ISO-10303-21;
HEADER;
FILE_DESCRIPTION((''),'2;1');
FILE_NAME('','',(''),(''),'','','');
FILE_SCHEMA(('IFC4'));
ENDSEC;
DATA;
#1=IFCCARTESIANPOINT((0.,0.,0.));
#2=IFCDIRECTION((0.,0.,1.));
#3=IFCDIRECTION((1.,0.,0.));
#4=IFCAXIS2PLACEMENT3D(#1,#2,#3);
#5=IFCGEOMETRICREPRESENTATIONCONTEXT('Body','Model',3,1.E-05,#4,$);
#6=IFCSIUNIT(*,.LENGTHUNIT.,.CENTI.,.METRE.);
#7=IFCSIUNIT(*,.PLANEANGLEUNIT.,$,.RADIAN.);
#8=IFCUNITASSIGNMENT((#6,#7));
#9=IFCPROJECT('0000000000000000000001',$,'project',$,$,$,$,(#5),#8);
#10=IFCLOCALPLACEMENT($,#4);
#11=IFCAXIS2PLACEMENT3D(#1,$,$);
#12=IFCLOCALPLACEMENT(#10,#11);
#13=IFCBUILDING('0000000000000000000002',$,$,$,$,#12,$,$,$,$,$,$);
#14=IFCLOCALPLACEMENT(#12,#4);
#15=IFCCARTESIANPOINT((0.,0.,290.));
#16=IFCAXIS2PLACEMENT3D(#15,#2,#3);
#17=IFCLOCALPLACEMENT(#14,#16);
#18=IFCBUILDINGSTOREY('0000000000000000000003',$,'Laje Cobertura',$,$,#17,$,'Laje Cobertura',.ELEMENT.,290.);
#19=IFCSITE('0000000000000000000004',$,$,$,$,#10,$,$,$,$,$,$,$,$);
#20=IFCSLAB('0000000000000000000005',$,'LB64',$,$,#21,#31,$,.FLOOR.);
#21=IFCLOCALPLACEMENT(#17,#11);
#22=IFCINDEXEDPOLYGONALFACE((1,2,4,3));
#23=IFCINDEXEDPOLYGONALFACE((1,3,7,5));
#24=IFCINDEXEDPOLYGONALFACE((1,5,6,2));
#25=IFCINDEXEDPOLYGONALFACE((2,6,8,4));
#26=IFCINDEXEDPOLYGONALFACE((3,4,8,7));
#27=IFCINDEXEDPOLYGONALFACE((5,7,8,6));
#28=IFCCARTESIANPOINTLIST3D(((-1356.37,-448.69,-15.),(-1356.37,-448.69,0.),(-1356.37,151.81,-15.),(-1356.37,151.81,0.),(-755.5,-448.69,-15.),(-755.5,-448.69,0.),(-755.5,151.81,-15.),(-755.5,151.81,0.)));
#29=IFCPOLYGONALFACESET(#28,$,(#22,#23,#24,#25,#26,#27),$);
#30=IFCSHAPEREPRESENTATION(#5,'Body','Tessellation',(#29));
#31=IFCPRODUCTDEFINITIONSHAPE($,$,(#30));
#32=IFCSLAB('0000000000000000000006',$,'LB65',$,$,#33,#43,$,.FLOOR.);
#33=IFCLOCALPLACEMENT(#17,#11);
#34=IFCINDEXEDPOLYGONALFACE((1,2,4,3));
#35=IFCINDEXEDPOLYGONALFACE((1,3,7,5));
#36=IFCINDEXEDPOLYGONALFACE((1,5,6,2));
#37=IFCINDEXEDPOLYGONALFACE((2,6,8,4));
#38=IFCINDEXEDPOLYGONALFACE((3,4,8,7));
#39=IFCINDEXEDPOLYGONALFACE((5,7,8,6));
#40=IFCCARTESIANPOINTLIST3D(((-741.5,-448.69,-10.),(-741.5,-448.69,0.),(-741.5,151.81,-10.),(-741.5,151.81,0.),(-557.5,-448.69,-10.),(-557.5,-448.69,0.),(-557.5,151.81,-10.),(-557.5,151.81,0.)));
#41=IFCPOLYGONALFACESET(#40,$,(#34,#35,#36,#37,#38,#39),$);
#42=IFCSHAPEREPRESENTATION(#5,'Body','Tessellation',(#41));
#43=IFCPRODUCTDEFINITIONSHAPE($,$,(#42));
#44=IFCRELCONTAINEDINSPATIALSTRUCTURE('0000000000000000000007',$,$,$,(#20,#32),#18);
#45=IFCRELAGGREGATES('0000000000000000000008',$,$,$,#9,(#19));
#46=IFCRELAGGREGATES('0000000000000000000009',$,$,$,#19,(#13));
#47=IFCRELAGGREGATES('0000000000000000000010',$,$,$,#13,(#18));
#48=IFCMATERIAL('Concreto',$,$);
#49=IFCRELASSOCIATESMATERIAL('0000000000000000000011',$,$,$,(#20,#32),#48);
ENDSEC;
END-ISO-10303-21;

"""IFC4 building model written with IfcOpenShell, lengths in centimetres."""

from ifc_helpers import new_model, si_unit, frame, origin, origin_with_axes, place, context, project, spatial, polyline, outline, extrude, material, element, save


model = new_model("IFC4")

# Units and contexts
model_context = context("Model", 3, precision=1e-05, world=origin_with_axes(), identifier="Body")
ifc_project = project(units=[si_unit("LENGTHUNIT", "METRE", prefix="CENTI"), si_unit("PLANEANGLEUNIT", "RADIAN")], contexts=[model_context])

# Site, building, storey
site_placement = place(None, origin_with_axes())
site = spatial("IfcSite", under=ifc_project, at=site_placement)
building_placement = place(site_placement, origin())
building = spatial("IfcBuilding", under=site, at=building_placement)
placement = place(building_placement, origin_with_axes())
storey_placement = place(placement, frame((0.0, 0.0, 290.0), z_axis=(0.0, 0.0, 1.0), x_axis=(1.0, 0.0, 0.0)))
storey = spatial("IfcBuildingStorey", under=building, at=storey_placement, Name="Laje Cobertura", LongName="Laje Cobertura", CompositionType="ELEMENT", Elevation=290.0)

# Shared definitions
ifc_material = material(Name="Concreto")

# Slabs
slab_1_placement = place(storey_placement, frame((-1055.93, -148.44, 0.0), z_axis=(0.0, 0.0, 1.0), x_axis=(1.0, 0.0, 0.0)))
element("IfcSlab", 1, at=slab_1_placement, inside=storey, material=ifc_material, Name="LB64", PredefinedType="FLOOR", context=model_context, shape_type="SolidModel", body=[
    extrude(outline(polyline([(300.44, 300.25), (-300.43, 300.25), (-300.43, -300.25), (300.44, -300.25), (300.44, 300.25), (300.44, 300.25)])), frame((0.0, 0.0, -15.0), z_axis=(0.0, 0.0, 1.0), x_axis=(1.0, 0.0, 0.0)), (0.0, 0.0, 1.0), 15.0),
])
slab_2_placement = place(storey_placement, frame((-649.5, -148.44, 0.0), z_axis=(0.0, 0.0, 1.0), x_axis=(1.0, 0.0, 0.0)))
element("IfcSlab", 2, at=slab_2_placement, inside=storey, material=ifc_material, Name="LB65", PredefinedType="FLOOR", context=model_context, shape_type="SolidModel", body=[
    extrude(outline(polyline([(92.0, 300.25), (-92.0, 300.25), (-92.0, -300.25), (92.0, -300.25), (92.0, 300.25), (92.0, 300.25)])), frame((0.0, 0.0, -10.0), z_axis=(0.0, 0.0, 1.0), x_axis=(1.0, 0.0, 0.0)), (0.0, 0.0, 1.0), 10.0),
])

save(model, "model.ifc")
